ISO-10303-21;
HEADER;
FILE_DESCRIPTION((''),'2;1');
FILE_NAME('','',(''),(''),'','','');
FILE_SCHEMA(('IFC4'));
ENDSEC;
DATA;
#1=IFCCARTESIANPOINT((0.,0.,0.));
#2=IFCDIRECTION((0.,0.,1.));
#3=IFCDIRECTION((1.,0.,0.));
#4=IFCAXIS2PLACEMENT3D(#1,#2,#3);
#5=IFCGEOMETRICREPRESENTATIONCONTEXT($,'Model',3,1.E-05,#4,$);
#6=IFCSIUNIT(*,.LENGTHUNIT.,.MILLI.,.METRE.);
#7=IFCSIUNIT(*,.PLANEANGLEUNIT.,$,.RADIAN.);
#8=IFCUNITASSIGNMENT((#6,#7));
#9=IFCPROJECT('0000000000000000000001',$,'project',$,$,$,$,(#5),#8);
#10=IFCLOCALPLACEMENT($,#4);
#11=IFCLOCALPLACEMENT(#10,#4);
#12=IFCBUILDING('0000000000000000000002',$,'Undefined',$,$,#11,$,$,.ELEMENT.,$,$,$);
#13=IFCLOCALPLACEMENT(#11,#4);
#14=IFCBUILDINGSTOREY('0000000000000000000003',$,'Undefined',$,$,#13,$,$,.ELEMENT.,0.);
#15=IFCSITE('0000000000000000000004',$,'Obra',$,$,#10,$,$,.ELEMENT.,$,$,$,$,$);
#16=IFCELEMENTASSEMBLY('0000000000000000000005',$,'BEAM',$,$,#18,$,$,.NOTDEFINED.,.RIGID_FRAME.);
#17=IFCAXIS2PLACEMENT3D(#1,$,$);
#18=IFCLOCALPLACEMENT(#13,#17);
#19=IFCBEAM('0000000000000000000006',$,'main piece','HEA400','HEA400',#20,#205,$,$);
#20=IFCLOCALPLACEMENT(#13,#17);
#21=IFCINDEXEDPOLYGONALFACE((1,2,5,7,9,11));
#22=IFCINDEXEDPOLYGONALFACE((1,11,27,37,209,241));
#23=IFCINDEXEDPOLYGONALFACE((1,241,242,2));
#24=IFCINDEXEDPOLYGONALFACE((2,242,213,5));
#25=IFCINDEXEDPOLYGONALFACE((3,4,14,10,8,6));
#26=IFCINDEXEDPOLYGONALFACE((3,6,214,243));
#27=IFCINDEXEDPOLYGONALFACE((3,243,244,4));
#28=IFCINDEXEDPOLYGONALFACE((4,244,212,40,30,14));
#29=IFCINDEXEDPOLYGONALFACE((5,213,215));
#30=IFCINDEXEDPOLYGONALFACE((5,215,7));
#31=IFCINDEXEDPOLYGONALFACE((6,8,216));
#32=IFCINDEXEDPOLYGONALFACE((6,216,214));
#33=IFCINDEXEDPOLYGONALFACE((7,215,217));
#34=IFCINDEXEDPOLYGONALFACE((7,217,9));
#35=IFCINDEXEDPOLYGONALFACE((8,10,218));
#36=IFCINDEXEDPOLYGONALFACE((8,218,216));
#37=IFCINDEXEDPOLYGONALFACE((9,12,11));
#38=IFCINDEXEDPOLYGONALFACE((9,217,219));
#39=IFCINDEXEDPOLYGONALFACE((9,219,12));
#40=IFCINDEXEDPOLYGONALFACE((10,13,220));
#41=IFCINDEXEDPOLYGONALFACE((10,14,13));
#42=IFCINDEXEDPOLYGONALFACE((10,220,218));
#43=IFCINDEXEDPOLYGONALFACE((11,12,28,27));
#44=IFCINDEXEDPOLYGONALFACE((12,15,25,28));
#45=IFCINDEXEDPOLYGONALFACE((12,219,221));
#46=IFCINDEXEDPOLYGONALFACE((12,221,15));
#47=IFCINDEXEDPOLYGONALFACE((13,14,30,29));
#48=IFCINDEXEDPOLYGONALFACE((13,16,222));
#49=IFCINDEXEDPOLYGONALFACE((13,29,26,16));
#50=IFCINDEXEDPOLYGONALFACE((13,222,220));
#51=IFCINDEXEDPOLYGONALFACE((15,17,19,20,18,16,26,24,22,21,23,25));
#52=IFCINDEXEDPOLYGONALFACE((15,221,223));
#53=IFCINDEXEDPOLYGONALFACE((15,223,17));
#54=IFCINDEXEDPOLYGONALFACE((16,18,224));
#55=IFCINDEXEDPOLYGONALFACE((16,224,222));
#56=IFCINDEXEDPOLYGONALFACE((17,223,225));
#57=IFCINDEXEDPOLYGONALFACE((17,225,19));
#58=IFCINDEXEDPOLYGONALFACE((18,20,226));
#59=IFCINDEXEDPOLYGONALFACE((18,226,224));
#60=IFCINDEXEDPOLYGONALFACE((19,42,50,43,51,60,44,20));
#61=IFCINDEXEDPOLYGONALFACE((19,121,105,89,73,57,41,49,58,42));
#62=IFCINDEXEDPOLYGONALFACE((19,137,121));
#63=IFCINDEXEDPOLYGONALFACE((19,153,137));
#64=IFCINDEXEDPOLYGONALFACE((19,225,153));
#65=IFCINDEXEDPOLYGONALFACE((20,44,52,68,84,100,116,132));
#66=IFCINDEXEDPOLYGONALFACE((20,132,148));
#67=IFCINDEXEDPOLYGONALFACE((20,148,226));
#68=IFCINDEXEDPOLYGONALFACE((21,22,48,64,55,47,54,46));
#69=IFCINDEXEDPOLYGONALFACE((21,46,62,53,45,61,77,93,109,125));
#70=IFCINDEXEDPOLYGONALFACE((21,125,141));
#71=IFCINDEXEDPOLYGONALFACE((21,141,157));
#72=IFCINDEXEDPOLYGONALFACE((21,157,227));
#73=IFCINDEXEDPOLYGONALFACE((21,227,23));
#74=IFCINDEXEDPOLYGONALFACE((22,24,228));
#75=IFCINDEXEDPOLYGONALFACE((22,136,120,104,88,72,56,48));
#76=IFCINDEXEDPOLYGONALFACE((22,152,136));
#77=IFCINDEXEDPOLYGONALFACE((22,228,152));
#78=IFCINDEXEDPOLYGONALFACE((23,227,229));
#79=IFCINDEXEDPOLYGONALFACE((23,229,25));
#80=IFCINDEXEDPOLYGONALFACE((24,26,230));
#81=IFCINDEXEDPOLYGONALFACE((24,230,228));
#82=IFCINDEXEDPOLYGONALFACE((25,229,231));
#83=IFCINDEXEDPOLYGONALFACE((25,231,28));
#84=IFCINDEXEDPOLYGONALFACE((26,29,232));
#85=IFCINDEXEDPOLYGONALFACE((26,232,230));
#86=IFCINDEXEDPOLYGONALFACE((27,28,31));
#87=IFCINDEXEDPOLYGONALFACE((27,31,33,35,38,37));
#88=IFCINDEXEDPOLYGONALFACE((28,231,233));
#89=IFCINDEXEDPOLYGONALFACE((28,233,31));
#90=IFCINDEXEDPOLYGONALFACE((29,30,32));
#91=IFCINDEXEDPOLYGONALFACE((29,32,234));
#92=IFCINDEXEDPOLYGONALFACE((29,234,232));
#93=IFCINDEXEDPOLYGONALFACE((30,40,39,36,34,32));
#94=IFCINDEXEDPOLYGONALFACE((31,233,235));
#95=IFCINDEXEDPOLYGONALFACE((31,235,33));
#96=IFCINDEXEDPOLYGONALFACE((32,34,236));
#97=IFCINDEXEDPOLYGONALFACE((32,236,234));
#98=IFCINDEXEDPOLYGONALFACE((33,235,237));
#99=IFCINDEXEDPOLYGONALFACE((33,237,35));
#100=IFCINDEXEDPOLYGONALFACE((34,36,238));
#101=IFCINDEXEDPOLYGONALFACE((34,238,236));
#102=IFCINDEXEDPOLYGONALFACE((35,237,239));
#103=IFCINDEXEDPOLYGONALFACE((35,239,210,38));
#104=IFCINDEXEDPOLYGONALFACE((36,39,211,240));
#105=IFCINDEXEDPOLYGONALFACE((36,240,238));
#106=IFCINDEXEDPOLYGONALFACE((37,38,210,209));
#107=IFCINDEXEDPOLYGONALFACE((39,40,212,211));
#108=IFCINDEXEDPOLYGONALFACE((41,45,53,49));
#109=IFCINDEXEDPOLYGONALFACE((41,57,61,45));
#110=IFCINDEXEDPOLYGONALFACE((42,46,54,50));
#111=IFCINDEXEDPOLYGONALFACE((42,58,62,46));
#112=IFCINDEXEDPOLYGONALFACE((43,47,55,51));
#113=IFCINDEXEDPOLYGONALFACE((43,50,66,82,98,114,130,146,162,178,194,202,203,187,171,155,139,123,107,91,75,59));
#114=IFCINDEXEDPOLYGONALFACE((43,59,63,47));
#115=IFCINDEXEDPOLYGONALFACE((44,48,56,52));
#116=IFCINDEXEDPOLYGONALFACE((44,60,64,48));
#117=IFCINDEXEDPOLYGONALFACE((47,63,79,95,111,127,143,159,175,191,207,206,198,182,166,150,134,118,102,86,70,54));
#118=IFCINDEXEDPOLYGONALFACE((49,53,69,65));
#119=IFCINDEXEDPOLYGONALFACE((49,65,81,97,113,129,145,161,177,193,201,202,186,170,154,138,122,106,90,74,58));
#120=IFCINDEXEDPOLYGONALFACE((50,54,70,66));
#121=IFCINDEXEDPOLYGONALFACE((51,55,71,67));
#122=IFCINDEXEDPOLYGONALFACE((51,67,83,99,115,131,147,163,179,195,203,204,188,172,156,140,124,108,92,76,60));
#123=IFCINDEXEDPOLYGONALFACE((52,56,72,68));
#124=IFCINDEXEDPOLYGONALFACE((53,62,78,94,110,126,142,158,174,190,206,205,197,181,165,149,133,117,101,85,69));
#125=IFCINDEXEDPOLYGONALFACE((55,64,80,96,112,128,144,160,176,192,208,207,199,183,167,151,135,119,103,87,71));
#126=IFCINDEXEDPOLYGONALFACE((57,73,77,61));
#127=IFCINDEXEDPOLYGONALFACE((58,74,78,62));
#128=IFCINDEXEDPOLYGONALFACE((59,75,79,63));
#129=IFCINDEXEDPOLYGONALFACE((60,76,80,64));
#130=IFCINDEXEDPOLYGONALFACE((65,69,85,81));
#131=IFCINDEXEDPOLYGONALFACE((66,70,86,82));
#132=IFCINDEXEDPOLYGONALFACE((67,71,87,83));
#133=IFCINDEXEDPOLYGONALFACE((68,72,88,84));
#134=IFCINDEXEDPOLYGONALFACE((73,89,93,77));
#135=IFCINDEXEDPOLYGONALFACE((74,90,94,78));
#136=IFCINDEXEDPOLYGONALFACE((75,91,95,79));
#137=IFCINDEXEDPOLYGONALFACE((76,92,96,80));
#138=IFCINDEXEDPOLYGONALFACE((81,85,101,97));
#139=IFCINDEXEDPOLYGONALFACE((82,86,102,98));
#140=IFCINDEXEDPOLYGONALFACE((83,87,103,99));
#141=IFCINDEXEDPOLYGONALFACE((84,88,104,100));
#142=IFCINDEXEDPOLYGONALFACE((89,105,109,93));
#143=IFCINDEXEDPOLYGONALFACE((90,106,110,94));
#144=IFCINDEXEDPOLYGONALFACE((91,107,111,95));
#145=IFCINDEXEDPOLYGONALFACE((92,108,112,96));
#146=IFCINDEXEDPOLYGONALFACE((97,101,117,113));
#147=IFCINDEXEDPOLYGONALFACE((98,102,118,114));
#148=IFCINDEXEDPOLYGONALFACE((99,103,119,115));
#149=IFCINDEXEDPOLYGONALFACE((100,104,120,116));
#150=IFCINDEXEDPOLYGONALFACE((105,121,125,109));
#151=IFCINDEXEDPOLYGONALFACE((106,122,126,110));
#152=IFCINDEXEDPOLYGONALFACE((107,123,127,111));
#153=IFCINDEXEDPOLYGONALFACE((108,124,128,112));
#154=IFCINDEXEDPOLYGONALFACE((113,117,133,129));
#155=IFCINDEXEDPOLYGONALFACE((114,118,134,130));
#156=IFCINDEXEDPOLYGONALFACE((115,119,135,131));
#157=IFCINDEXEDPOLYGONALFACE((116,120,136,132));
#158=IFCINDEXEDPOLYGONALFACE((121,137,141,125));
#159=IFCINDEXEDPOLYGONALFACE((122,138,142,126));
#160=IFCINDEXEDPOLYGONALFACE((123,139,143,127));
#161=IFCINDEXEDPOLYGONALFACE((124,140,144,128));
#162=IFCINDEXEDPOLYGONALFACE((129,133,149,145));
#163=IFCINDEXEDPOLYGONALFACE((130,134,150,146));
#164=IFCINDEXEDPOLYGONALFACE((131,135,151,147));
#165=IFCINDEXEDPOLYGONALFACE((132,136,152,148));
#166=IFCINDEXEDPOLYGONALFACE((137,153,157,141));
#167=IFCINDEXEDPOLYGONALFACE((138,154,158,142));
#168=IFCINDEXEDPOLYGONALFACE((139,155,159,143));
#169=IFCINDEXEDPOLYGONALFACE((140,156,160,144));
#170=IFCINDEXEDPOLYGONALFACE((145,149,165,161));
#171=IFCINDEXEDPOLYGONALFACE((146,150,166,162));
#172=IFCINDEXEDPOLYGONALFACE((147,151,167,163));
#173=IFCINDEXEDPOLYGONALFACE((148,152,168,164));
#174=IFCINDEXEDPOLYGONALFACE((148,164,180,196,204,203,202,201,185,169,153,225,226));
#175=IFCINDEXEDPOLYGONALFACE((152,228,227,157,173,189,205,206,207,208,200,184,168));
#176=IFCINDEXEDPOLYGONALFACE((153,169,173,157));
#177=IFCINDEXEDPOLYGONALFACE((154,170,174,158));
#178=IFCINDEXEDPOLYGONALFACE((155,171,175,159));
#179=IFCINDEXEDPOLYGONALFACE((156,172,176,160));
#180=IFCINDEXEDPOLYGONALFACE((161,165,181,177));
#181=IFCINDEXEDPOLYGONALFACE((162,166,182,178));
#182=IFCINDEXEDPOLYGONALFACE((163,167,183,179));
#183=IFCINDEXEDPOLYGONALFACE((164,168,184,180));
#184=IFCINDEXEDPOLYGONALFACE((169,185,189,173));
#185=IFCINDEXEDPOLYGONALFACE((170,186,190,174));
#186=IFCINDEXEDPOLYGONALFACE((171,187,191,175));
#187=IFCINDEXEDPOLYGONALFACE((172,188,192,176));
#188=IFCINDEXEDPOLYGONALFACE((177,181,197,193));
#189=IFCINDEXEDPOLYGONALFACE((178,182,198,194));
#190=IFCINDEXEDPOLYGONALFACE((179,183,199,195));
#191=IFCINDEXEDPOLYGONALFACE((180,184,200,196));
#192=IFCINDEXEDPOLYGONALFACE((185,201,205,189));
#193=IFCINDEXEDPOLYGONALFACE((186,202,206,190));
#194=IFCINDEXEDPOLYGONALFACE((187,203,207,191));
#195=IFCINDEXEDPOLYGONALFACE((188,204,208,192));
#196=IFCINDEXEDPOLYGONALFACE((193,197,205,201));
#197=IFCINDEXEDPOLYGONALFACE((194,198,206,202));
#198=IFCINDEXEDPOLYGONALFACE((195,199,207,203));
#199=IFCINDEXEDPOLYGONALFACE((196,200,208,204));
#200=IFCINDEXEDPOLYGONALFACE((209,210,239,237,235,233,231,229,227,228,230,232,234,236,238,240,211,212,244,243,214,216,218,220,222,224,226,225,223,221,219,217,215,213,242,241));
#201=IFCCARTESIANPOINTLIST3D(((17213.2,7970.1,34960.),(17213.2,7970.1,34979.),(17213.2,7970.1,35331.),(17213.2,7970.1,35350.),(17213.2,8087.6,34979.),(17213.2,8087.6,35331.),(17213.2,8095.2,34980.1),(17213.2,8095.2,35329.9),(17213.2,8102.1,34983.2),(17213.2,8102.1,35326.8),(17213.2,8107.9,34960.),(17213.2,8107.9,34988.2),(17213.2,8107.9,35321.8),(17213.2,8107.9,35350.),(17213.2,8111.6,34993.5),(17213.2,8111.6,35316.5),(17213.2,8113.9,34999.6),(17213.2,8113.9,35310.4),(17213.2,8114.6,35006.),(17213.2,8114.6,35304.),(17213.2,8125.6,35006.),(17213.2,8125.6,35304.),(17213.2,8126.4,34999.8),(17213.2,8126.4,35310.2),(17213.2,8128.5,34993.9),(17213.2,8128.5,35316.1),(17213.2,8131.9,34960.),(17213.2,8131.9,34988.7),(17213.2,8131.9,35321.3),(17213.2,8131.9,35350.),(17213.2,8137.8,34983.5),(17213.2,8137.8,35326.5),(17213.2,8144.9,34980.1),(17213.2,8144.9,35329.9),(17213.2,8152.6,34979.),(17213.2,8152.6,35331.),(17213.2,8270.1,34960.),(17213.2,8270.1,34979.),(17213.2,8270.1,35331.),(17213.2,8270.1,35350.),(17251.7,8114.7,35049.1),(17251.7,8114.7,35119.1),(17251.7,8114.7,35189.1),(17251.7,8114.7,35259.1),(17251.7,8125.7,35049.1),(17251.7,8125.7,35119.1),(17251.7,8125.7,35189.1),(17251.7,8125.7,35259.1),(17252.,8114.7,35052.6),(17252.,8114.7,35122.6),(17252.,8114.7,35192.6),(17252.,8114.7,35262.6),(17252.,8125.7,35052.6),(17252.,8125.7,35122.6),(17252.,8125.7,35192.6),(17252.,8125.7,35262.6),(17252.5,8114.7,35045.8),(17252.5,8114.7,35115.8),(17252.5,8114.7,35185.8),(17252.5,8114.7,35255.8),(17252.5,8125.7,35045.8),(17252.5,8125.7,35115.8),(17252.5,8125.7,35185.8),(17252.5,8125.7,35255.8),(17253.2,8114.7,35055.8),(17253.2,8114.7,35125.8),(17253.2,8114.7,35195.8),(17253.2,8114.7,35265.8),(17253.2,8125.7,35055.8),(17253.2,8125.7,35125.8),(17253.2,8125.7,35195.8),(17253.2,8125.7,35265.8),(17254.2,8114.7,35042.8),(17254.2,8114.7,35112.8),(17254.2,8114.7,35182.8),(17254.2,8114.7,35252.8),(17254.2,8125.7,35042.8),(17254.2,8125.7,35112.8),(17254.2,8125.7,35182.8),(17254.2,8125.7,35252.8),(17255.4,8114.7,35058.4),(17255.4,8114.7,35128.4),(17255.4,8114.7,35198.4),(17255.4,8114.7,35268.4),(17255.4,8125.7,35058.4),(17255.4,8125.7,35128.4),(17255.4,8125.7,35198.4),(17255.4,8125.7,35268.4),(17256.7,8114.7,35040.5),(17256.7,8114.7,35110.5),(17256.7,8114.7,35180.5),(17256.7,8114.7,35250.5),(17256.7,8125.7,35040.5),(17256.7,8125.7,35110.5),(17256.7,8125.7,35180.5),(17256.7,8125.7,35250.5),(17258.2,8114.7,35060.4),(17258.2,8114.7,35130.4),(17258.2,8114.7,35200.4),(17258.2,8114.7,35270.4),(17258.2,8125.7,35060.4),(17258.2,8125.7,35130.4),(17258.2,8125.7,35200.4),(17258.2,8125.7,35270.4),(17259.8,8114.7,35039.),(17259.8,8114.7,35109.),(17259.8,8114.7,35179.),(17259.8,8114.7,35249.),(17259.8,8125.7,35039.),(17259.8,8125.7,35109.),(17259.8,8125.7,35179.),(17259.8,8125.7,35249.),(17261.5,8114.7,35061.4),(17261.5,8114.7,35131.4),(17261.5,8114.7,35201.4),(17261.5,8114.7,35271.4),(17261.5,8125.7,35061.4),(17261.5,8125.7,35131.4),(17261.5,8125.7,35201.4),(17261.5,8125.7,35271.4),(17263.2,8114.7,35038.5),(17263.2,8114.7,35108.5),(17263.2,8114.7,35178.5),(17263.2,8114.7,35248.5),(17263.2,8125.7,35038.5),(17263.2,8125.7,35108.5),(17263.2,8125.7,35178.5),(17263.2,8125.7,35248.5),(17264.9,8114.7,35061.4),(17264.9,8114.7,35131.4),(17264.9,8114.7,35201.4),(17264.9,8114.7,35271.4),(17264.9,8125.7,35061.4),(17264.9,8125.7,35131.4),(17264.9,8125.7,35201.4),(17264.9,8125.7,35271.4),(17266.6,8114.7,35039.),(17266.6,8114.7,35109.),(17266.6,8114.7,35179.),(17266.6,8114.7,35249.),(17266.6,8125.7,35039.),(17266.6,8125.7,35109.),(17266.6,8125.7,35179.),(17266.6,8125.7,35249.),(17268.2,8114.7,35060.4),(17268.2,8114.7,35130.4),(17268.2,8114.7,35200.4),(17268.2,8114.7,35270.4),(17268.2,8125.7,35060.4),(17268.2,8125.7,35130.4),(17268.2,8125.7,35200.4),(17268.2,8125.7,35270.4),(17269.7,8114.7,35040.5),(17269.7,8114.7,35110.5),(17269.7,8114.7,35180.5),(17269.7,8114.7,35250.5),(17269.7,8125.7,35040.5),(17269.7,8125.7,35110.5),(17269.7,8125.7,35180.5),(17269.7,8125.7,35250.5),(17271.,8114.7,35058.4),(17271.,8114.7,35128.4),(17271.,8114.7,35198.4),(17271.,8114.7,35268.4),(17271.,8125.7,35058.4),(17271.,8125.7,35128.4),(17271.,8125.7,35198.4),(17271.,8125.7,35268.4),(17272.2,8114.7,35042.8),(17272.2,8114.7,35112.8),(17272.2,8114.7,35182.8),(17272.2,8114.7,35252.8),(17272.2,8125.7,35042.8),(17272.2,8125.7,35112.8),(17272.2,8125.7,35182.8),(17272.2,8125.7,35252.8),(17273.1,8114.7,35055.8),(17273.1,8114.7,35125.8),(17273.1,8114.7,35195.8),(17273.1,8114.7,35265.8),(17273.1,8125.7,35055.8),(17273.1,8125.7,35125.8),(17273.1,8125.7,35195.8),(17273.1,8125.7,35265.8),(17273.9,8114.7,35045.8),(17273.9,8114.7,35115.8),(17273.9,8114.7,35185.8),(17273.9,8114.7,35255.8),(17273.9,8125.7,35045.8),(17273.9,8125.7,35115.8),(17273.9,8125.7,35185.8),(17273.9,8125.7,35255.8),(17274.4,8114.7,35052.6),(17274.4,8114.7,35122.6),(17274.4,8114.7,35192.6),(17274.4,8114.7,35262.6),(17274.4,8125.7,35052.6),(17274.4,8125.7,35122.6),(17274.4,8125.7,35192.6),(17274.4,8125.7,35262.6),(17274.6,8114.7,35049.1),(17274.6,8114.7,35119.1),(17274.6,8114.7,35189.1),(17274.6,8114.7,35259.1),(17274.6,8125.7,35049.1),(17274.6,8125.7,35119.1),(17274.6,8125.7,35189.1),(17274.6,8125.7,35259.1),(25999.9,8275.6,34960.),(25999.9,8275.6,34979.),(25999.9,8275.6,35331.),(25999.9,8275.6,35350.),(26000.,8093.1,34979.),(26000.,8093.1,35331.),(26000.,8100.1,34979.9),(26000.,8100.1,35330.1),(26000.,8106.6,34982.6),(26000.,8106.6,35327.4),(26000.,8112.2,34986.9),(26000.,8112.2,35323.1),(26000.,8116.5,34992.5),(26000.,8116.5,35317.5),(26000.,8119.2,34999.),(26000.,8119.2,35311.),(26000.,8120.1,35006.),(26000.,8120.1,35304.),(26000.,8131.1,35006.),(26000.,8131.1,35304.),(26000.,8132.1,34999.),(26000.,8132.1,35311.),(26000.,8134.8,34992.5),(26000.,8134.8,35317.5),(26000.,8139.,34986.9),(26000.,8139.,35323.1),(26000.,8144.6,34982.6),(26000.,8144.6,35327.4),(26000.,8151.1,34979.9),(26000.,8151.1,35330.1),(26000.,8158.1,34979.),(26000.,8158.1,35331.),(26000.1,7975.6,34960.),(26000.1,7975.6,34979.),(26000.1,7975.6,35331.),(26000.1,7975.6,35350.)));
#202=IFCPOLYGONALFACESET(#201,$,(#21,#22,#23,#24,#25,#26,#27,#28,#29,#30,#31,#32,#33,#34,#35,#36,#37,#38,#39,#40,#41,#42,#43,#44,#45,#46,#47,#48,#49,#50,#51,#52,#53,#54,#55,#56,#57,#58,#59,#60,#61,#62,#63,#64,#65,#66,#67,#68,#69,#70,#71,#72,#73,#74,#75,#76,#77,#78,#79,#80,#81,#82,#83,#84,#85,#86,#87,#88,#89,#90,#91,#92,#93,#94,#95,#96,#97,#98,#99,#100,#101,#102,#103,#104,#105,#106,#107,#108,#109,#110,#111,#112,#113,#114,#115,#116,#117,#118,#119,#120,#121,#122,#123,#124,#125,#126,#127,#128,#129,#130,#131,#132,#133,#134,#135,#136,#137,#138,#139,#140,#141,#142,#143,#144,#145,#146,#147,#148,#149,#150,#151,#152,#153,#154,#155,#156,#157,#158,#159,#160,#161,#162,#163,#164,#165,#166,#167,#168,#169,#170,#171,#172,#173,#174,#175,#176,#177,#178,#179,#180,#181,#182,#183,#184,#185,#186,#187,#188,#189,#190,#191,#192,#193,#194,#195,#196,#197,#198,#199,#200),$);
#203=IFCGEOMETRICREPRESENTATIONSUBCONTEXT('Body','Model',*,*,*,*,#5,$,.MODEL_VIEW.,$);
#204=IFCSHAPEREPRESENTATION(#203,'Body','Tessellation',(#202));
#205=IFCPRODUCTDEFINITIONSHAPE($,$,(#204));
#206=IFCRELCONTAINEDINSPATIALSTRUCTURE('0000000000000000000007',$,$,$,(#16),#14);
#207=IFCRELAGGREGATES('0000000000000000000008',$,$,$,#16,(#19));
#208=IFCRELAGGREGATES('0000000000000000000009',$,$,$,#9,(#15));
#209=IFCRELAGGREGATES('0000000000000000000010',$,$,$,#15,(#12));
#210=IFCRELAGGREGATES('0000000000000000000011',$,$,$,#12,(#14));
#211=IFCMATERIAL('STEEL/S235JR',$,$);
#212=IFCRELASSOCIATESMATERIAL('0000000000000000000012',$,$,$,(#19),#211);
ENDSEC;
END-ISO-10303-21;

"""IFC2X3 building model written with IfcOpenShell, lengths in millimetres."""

from ifc_helpers import new_model, si_unit, frame, origin_with_axes, origin_2d_with_axis, place, context, subcontext, project, spatial, rectangle, circle, i_section, extrude, clip, halfspace, source, transform, mapped, material, element, aggregate, save


model = new_model("IFC2X3")

# Units and contexts
model_context = context("Model", 3, precision=1e-05, world=origin_with_axes())
body_context = subcontext(model_context, "Body", "Model", "MODEL_VIEW")
ifc_project = project(units=[si_unit("LENGTHUNIT", "METRE", prefix="MILLI"), si_unit("PLANEANGLEUNIT", "RADIAN")], contexts=[model_context])

# Site, building, storey
site_placement = place(None, origin_with_axes())
site = spatial("IfcSite", under=ifc_project, at=site_placement, Name="Obra", CompositionType="ELEMENT")
building_placement = place(site_placement, origin_with_axes())
building = spatial("IfcBuilding", under=site, at=building_placement, Name="Undefined", CompositionType="ELEMENT")
storey_placement = place(building_placement, origin_with_axes())
storey = spatial("IfcBuildingStorey", under=building, at=storey_placement, Name="Undefined", CompositionType="ELEMENT", Elevation=0.0)

# Shared definitions
ifc_material_1 = material(Name="STEEL/S235JR")

# Element assembly, beam, openings
assembly_1_placement = place(storey_placement, origin_with_axes())
assembly_1 = element("IfcElementAssembly", 1, at=assembly_1_placement, inside=storey, Name="BEAM", AssemblyPlace="NOTDEFINED", PredefinedType="RIGID_FRAME")
beam_1_placement = place(assembly_1_placement, frame((17223.4, 8120.1, 35155.0), z_axis=(0.0, 0.0, 1.0), x_axis=(1.0, 0.000627, 0.0)))
beam_1 = element("IfcBeam", 2, at=beam_1_placement, material=ifc_material_1, Name="main piece", Description="HEA400", ObjectType="HEA400", context=body_context, shape_type="Clipping", body=[
    clip(extrude(i_section(OverallWidth=300.0, OverallDepth=390.0, WebThickness=11.0, FlangeThickness=19.0, FilletRadius=27.0, at=origin_2d_with_axis()), frame((8776.6, 0.0, 0.0), z_axis=(-1.0, 0.0, 0.0), x_axis=(0.0, -1.0, 0.0)), (0.0, 0.0, 1.0), 8787.1), halfspace(frame((-10.2, 0.0, -295.0), z_axis=(1.0, -0.000627, 0.0), x_axis=(-0.000627, -1.0, 0.0)), True)),
])
opening_1_placement = place(assembly_1_placement, frame((17223.4, 8120.1, 35155.0), z_axis=(0.0, 0.0, 1.0), x_axis=(1.0, 0.000627, 0.0)))
element("IfcOpeningElement", 3, at=opening_1_placement, cuts=beam_1, ObjectType="Recess", context=body_context, shape_type="SweptSolid", body=[
    extrude(rectangle(XDim=12.0, YDim=168.7, at=origin_2d_with_axis()), frame((-16.2, 72.2, 196.0), z_axis=(0.0, 0.0, -1.0), x_axis=(1.0, -0.000627, 0.0)), (0.0, 0.0, 1.0), 392.0),
])
opening_2_placement = place(assembly_1_placement, frame((17223.4, 8120.1, 35155.0), z_axis=(0.0, 0.0, 1.0), x_axis=(1.0, 0.000627, 0.0)))
element("IfcOpeningElement", 4, at=opening_2_placement, cuts=beam_1, ObjectType="Recess", context=body_context, shape_type="SweptSolid", body=[
    extrude(rectangle(XDim=12.0, YDim=162.8, at=origin_2d_with_axis()), frame((-16.3, -69.6, 196.0), z_axis=(0.0, 0.0, -1.0), x_axis=(1.0, -0.000627, 0.0)), (0.0, 0.0, 1.0), 392.0),
])
shared_shape_1 = source(origin_with_axes(), body_context, "Body", "SweptSolid", [
    extrude(circle(Radius=11.5, at=origin_2d_with_axis()), frame((0.0, -5.6, 0.0), z_axis=(0.0, 1.0, 0.0), x_axis=(1.0, 0.0, 0.0)), (0.0, 0.0, 1.0), 11.2),
])
opening_3_placement = place(assembly_1_placement, frame((17213.2, 8120.1, 35350.0), z_axis=(1.0, 0.0, 0.0), x_axis=(0.0, 0.0, -1.0)))
element("IfcOpeningElement", 5, at=opening_3_placement, cuts=beam_1, ObjectType="Opening", context=body_context, shape_type="MappedRepresentation", body=[
    mapped(shared_shape_1, transform((90.0, 0.0, 50.0))),
    mapped(shared_shape_1, transform((160.0, 0.0, 50.0))),
    mapped(shared_shape_1, transform((230.0, 0.0, 50.0))),
    mapped(shared_shape_1, transform((300.0, 0.0, 50.0))),
])

aggregate(assembly_1, [beam_1])

save(model, "model.ifc")
